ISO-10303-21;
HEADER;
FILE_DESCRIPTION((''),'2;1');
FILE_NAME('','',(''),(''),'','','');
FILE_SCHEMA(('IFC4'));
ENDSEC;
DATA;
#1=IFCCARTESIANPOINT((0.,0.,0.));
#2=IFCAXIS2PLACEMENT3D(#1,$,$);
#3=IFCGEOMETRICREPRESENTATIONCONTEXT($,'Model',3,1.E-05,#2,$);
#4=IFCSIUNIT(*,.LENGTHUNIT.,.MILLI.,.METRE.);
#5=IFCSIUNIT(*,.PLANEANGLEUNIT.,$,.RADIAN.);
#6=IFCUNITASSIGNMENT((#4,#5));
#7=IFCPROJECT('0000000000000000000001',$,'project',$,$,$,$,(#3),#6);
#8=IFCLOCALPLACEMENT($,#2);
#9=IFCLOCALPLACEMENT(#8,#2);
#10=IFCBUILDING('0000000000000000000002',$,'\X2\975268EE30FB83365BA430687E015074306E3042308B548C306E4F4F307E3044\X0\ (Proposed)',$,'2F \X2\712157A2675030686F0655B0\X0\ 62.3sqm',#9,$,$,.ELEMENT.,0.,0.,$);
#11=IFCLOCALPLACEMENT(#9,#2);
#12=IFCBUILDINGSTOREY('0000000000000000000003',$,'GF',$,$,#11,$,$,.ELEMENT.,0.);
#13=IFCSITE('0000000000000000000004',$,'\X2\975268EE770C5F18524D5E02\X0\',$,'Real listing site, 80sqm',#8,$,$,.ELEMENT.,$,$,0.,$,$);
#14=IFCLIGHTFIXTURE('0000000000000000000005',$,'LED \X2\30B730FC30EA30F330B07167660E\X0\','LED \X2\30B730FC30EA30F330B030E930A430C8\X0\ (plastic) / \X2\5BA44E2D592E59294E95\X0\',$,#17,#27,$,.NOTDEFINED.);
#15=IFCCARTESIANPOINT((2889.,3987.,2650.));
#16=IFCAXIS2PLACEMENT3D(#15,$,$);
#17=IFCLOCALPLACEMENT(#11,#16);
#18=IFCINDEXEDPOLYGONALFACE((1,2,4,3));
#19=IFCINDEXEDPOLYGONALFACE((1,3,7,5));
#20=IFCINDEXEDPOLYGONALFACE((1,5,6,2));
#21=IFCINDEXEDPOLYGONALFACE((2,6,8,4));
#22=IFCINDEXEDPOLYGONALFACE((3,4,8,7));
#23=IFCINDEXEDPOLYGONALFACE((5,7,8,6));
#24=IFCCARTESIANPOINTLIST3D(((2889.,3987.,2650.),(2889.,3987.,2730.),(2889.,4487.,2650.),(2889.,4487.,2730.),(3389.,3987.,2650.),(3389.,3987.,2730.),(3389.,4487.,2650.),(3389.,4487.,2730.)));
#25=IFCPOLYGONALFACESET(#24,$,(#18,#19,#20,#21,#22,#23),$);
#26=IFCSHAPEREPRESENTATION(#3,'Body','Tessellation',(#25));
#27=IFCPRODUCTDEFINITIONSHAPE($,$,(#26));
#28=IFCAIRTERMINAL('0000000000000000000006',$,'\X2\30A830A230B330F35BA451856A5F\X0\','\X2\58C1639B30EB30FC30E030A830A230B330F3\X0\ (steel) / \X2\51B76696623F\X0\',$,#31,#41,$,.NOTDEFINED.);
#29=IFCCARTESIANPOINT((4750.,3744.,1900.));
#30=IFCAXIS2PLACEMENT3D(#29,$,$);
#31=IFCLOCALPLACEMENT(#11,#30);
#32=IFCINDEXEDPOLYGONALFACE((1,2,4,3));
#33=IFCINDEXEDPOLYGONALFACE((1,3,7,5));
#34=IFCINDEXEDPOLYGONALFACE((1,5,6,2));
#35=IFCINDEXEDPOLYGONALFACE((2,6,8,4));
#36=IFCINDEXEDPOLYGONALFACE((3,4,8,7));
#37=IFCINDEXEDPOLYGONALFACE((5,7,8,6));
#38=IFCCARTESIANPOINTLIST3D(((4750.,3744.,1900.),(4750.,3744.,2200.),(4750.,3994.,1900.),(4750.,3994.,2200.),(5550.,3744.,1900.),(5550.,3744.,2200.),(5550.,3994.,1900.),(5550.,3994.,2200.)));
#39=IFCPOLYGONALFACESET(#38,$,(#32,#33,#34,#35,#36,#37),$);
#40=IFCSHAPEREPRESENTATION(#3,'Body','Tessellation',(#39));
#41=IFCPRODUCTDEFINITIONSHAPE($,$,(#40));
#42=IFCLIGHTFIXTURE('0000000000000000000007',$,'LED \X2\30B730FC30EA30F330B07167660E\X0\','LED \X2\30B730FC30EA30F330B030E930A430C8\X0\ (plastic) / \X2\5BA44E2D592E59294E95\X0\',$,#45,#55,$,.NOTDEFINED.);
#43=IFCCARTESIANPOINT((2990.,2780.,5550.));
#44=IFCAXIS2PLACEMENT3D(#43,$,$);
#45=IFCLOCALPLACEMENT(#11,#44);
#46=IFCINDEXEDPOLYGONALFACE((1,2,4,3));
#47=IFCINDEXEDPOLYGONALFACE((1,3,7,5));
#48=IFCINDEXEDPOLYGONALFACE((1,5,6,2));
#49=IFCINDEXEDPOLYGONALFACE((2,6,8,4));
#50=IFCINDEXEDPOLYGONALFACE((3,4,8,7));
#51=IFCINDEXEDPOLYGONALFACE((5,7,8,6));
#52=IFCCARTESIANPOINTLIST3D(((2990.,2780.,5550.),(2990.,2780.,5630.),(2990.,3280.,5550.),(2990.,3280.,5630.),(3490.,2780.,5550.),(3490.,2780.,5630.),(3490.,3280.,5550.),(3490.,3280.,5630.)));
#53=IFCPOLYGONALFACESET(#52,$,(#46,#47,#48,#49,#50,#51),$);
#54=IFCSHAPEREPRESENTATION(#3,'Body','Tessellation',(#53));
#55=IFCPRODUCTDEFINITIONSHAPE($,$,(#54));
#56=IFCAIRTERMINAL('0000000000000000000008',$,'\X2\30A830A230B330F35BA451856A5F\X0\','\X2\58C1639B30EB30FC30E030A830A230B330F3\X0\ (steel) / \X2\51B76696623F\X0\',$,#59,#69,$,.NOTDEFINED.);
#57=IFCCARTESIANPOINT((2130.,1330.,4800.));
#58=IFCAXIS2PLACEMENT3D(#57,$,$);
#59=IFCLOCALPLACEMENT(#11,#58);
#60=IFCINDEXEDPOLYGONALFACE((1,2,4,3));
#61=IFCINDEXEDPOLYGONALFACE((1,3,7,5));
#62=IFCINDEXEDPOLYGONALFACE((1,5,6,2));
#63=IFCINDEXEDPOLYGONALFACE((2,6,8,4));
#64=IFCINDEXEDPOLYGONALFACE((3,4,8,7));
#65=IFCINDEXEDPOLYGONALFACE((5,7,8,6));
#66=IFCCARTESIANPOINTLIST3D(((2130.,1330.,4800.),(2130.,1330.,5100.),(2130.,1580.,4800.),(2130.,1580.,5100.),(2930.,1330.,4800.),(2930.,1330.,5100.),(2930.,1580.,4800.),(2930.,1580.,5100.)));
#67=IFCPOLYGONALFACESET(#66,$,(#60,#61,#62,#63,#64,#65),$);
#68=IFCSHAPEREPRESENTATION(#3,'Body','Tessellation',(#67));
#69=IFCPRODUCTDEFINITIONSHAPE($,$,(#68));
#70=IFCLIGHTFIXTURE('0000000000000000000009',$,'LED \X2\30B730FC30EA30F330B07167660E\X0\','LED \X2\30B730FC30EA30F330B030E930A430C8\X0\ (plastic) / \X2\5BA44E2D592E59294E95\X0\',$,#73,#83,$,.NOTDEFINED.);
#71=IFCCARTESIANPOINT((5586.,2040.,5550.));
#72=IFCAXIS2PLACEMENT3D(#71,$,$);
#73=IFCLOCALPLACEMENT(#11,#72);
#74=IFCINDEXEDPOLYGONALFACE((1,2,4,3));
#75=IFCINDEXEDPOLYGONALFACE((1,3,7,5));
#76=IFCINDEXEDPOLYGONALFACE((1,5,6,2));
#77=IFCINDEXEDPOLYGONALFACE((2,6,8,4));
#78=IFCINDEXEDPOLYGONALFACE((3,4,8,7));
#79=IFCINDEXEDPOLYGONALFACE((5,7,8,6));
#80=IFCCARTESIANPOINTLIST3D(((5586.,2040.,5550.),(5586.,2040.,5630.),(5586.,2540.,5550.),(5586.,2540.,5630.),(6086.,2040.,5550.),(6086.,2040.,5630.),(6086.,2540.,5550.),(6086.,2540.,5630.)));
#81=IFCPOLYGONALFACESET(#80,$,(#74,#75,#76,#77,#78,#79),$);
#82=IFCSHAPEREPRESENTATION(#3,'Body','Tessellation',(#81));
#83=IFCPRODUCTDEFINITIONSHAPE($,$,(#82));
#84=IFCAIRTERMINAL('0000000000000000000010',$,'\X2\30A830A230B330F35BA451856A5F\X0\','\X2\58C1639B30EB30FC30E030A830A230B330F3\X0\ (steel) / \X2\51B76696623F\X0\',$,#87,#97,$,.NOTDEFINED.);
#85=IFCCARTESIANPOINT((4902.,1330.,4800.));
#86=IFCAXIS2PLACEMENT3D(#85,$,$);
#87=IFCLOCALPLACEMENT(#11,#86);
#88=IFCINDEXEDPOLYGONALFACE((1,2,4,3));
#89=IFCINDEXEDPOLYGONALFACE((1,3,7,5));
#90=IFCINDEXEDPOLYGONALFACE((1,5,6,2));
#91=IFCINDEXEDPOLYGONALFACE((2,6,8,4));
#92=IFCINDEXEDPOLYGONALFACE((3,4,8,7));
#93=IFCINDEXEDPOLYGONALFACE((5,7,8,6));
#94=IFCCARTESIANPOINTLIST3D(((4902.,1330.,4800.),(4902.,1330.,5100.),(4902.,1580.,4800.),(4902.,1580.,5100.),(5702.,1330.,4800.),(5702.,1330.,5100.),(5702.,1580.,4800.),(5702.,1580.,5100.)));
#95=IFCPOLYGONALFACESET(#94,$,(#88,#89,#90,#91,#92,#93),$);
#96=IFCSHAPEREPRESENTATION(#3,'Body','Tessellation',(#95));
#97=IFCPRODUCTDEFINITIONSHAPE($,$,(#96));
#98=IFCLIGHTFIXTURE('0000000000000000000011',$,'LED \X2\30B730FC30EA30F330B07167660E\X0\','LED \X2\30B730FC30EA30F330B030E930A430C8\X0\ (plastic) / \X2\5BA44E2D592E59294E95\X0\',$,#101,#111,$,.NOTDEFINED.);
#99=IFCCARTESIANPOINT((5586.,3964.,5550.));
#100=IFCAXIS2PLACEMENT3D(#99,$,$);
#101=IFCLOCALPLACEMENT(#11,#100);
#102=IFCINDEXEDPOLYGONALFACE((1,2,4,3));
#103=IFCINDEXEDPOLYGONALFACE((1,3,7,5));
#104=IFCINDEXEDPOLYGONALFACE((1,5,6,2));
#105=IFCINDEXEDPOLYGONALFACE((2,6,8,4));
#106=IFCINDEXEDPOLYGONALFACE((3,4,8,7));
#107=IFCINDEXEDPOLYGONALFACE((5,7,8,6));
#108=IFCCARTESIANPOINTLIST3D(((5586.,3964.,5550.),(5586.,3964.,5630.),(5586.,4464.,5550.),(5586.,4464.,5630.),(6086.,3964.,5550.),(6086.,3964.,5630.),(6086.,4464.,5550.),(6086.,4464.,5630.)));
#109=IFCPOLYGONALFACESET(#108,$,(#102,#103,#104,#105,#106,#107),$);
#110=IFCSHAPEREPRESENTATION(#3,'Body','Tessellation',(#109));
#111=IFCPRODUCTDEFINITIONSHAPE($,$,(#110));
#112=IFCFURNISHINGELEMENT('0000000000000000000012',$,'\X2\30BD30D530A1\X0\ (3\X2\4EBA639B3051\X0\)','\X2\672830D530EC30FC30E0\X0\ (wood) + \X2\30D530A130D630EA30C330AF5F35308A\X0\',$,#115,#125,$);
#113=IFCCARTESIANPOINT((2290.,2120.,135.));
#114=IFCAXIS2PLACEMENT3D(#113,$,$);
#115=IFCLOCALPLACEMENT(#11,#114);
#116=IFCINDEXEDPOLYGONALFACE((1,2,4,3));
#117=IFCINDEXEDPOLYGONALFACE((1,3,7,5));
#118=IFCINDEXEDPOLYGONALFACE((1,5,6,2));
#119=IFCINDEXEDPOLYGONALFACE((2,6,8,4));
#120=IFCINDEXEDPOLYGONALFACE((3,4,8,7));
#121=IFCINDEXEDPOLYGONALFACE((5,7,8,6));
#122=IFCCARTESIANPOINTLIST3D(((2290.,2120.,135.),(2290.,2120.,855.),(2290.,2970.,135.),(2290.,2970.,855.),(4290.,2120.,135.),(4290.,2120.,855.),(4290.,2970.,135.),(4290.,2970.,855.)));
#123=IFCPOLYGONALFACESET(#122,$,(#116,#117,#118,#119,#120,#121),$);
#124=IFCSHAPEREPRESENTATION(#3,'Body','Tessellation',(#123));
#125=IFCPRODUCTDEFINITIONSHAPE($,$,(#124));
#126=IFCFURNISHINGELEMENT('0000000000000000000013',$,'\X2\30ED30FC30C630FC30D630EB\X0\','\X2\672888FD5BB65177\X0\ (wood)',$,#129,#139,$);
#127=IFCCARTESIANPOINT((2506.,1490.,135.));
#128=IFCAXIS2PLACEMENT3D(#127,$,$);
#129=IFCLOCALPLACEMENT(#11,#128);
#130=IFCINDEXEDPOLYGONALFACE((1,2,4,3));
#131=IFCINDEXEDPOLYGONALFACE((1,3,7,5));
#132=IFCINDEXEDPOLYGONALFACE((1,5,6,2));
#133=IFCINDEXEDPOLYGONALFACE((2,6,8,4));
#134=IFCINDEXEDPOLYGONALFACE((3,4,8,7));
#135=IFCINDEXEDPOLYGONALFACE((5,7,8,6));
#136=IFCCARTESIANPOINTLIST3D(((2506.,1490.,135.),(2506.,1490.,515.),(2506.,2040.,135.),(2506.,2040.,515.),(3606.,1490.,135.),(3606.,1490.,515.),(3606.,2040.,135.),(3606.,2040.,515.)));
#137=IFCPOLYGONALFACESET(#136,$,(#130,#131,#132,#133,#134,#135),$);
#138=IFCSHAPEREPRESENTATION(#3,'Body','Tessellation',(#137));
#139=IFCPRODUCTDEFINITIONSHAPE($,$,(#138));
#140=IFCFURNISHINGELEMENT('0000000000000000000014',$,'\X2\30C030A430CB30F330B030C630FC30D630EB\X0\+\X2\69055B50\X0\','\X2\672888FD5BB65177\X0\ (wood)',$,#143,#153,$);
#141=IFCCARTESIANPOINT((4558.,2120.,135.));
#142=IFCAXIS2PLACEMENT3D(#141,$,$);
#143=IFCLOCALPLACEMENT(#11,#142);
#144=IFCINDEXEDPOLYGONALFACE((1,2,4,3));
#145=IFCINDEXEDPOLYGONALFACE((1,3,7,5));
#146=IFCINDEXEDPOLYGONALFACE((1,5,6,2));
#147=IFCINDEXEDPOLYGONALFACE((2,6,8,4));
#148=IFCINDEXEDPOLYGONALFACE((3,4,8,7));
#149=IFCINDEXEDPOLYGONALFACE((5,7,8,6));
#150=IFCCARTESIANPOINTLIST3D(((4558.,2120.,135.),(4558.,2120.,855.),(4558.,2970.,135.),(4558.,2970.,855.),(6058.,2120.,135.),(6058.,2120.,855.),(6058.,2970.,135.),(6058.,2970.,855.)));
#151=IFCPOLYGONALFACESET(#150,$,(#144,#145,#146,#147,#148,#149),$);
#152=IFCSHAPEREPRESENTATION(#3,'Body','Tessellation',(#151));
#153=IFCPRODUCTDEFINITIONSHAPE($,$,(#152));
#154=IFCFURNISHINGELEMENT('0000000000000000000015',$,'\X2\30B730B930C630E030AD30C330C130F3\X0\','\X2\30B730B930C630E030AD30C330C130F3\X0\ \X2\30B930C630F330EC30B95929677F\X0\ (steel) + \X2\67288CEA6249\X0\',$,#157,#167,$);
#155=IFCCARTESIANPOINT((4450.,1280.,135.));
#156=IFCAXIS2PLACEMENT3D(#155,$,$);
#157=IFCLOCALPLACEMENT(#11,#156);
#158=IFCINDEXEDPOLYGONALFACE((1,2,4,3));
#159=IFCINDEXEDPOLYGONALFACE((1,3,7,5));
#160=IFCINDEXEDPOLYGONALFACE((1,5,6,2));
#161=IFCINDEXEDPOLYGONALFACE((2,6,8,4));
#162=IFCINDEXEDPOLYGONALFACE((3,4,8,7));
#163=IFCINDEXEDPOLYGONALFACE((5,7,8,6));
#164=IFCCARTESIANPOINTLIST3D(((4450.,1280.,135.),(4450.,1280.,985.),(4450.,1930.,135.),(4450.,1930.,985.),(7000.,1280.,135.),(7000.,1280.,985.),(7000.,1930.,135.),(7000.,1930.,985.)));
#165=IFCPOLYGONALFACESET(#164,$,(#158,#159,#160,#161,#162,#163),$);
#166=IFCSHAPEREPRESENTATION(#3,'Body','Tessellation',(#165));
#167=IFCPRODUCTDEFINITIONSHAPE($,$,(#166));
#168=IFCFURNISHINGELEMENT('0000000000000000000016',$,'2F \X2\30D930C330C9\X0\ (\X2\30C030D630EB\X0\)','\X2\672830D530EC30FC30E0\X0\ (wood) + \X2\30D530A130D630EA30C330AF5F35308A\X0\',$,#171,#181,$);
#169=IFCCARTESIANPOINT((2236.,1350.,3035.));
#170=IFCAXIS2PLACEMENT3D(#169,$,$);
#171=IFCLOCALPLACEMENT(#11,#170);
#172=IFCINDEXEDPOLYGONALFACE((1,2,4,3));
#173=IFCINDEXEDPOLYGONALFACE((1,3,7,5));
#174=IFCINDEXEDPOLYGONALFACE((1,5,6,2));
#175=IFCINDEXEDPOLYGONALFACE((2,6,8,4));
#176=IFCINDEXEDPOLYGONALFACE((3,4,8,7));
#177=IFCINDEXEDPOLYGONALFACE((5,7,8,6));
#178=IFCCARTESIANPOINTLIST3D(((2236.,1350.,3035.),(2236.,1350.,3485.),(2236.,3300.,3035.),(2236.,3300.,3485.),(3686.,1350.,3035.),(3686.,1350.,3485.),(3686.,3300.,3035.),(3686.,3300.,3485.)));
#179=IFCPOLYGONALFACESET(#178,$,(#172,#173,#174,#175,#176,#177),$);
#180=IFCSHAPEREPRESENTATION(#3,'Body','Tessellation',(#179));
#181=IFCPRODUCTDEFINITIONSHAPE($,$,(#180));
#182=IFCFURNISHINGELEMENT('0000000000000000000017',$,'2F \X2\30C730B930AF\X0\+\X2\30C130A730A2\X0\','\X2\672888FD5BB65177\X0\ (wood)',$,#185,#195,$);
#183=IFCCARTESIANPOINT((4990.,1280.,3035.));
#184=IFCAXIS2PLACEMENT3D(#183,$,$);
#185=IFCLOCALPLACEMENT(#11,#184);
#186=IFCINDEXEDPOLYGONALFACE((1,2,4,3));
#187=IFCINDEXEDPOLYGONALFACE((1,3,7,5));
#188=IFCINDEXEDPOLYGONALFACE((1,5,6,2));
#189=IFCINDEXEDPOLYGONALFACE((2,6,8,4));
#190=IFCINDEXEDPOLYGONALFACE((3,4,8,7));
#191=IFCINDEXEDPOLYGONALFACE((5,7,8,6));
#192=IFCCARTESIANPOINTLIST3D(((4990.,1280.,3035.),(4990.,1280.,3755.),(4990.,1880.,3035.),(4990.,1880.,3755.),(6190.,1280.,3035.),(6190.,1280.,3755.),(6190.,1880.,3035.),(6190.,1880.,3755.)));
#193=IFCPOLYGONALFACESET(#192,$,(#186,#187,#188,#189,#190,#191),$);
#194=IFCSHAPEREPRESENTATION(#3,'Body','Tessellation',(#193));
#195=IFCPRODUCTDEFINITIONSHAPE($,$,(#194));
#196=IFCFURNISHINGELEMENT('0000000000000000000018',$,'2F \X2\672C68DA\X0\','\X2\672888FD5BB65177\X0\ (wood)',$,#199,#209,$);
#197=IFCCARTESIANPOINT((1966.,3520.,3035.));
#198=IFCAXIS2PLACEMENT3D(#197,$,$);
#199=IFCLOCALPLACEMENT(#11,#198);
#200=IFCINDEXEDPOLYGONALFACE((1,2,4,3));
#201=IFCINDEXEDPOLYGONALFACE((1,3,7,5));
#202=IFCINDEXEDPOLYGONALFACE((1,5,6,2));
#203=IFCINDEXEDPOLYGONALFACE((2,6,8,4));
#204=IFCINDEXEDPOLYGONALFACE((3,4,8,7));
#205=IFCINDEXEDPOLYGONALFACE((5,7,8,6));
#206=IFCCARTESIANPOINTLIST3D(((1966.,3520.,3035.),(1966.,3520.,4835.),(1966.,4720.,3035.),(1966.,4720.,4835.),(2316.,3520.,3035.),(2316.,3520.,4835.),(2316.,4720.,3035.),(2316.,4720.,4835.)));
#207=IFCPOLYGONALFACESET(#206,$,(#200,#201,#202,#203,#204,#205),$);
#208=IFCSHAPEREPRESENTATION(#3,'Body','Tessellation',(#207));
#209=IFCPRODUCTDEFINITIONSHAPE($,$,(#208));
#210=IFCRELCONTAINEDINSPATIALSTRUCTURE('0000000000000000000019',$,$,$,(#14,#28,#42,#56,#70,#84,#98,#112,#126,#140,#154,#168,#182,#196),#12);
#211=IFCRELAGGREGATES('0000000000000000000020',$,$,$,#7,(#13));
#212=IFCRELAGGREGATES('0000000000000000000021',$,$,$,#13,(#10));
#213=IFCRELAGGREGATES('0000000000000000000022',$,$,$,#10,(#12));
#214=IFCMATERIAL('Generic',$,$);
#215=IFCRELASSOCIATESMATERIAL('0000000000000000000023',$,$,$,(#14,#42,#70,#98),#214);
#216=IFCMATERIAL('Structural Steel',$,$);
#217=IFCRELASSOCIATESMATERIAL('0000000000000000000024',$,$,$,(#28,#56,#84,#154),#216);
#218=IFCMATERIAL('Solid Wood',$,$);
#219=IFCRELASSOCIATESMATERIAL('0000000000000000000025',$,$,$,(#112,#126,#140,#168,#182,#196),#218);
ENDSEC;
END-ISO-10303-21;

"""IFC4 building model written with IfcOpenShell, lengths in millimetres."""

from ifc_helpers import new_model, si_unit, frame, frame_2d, origin, place, context, project, spatial, rectangle, extrude, material, element, save


model = new_model("IFC4")

# Units and contexts
model_context = context("Model", 3, precision=1e-05, world=origin())
ifc_project = project(units=[si_unit("LENGTHUNIT", "METRE", prefix="MILLI"), si_unit("PLANEANGLEUNIT", "RADIAN")], contexts=[model_context])

# Site, building, storey
site_placement = place(None, origin())
site = spatial("IfcSite", under=ifc_project, at=site_placement, Name="青森県弘前市", ObjectType="Real listing site, 80sqm", CompositionType="ELEMENT", RefElevation=0.0)
building_placement = place(site_placement, origin())
building = spatial("IfcBuilding", under=site, at=building_placement, Name="青森・茶室と縁側のある和の住まい (Proposed)", ObjectType="2F 無垢材と漆喰 62.3sqm", CompositionType="ELEMENT", ElevationOfRefHeight=0.0, ElevationOfTerrain=0.0)
storey_placement = place(building_placement, origin())
storey = spatial("IfcBuildingStorey", under=building, at=storey_placement, Name="GF", CompositionType="ELEMENT", Elevation=0.0)

# Shared definitions
ifc_material_1 = material(Name="Solid Wood")

# Shared definitions
ifc_material_2 = material(Name="Structural Steel")

# Shared definitions
ifc_material_3 = material(Name="Generic")

# Light fixture
light_fixture_1_placement = place(storey_placement, frame((2889.0, 3987.0, 2650.0)))
element("IfcLightFixture", 1, at=light_fixture_1_placement, inside=storey, material=ifc_material_3, Name="LED シーリング照明", Description="LED シーリングライト (plastic) / 室中央天井", PredefinedType="NOTDEFINED", context=model_context, shape_type="SweptSolid", body=[
    extrude(rectangle(XDim=500.0, YDim=500.0, at=frame_2d((250.0, 250.0))), frame((2889.0, 3987.0, 2650.0)), (0.0, 0.0, 1.0), 80.0),
])

# Air terminal
air_terminal_1_placement = place(storey_placement, frame((4750.0, 3744.0, 1900.0)))
element("IfcAirTerminal", 2, at=air_terminal_1_placement, inside=storey, material=ifc_material_2, Name="エアコン室内機", Description="壁掛ルームエアコン (steel) / 冷暖房", PredefinedType="NOTDEFINED", context=model_context, shape_type="SweptSolid", body=[
    extrude(rectangle(XDim=800.0, YDim=250.0, at=frame_2d((400.0, 125.0))), frame((4750.0, 3744.0, 1900.0)), (0.0, 0.0, 1.0), 300.0),
])

# Light fixture
light_fixture_2_placement = place(storey_placement, frame((2990.0, 2780.0, 5550.0)))
element("IfcLightFixture", 3, at=light_fixture_2_placement, inside=storey, material=ifc_material_3, Name="LED シーリング照明", Description="LED シーリングライト (plastic) / 室中央天井", PredefinedType="NOTDEFINED", context=model_context, shape_type="SweptSolid", body=[
    extrude(rectangle(XDim=500.0, YDim=500.0, at=frame_2d((250.0, 250.0))), frame((2990.0, 2780.0, 5550.0)), (0.0, 0.0, 1.0), 80.0),
])

# Air terminal
air_terminal_2_placement = place(storey_placement, frame((2130.0, 1330.0, 4800.0)))
element("IfcAirTerminal", 4, at=air_terminal_2_placement, inside=storey, material=ifc_material_2, Name="エアコン室内機", Description="壁掛ルームエアコン (steel) / 冷暖房", PredefinedType="NOTDEFINED", context=model_context, shape_type="SweptSolid", body=[
    extrude(rectangle(XDim=800.0, YDim=250.0, at=frame_2d((400.0, 125.0))), frame((2130.0, 1330.0, 4800.0)), (0.0, 0.0, 1.0), 300.0),
])

# Light fixture
light_fixture_3_placement = place(storey_placement, frame((5586.0, 2040.0, 5550.0)))
element("IfcLightFixture", 5, at=light_fixture_3_placement, inside=storey, material=ifc_material_3, Name="LED シーリング照明", Description="LED シーリングライト (plastic) / 室中央天井", PredefinedType="NOTDEFINED", context=model_context, shape_type="SweptSolid", body=[
    extrude(rectangle(XDim=500.0, YDim=500.0, at=frame_2d((250.0, 250.0))), frame((5586.0, 2040.0, 5550.0)), (0.0, 0.0, 1.0), 80.0),
])

# Air terminal
air_terminal_3_placement = place(storey_placement, frame((4902.0, 1330.0, 4800.0)))
element("IfcAirTerminal", 6, at=air_terminal_3_placement, inside=storey, material=ifc_material_2, Name="エアコン室内機", Description="壁掛ルームエアコン (steel) / 冷暖房", PredefinedType="NOTDEFINED", context=model_context, shape_type="SweptSolid", body=[
    extrude(rectangle(XDim=800.0, YDim=250.0, at=frame_2d((400.0, 125.0))), frame((4902.0, 1330.0, 4800.0)), (0.0, 0.0, 1.0), 300.0),
])

# Light fixture
light_fixture_4_placement = place(storey_placement, frame((5586.0, 3964.0, 5550.0)))
element("IfcLightFixture", 7, at=light_fixture_4_placement, inside=storey, material=ifc_material_3, Name="LED シーリング照明", Description="LED シーリングライト (plastic) / 室中央天井", PredefinedType="NOTDEFINED", context=model_context, shape_type="SweptSolid", body=[
    extrude(rectangle(XDim=500.0, YDim=500.0, at=frame_2d((250.0, 250.0))), frame((5586.0, 3964.0, 5550.0)), (0.0, 0.0, 1.0), 80.0),
])

# Furnishing elements
furnishing_1_placement = place(storey_placement, frame((2290.0, 2120.0, 135.0)))
element("IfcFurnishingElement", 8, at=furnishing_1_placement, inside=storey, material=ifc_material_1, Name="ソファ (3人掛け)", Description="木フレーム (wood) + ファブリック張り", context=model_context, shape_type="SweptSolid", body=[
    extrude(rectangle(XDim=2000.0, YDim=850.0, at=frame_2d((1000.0, 425.0))), frame((2290.0, 2120.0, 135.0)), (0.0, 0.0, 1.0), 720.0),
])
furnishing_2_placement = place(storey_placement, frame((2506.0, 1490.0, 135.0)))
element("IfcFurnishingElement", 9, at=furnishing_2_placement, inside=storey, material=ifc_material_1, Name="ローテーブル", Description="木製家具 (wood)", context=model_context, shape_type="SweptSolid", body=[
    extrude(rectangle(XDim=1100.0, YDim=550.0, at=frame_2d((550.0, 275.0))), frame((2506.0, 1490.0, 135.0)), (0.0, 0.0, 1.0), 380.0),
])
furnishing_3_placement = place(storey_placement, frame((4558.0, 2120.0, 135.0)))
element("IfcFurnishingElement", 10, at=furnishing_3_placement, inside=storey, material=ifc_material_1, Name="ダイニングテーブル+椅子", Description="木製家具 (wood)", context=model_context, shape_type="SweptSolid", body=[
    extrude(rectangle(XDim=1500.0, YDim=850.0, at=frame_2d((750.0, 425.0))), frame((4558.0, 2120.0, 135.0)), (0.0, 0.0, 1.0), 720.0),
])
furnishing_4_placement = place(storey_placement, frame((4450.0, 1280.0, 135.0)))
element("IfcFurnishingElement", 11, at=furnishing_4_placement, inside=storey, material=ifc_material_2, Name="システムキッチン", Description="システムキッチン ステンレス天板 (steel) + 木質扉", context=model_context, shape_type="SweptSolid", body=[
    extrude(rectangle(XDim=2550.0, YDim=650.0, at=frame_2d((1275.0, 325.0))), frame((4450.0, 1280.0, 135.0)), (0.0, 0.0, 1.0), 850.0),
])
furnishing_5_placement = place(storey_placement, frame((2236.0, 1350.0, 3035.0)))
element("IfcFurnishingElement", 12, at=furnishing_5_placement, inside=storey, material=ifc_material_1, Name="2F ベッド (ダブル)", Description="木フレーム (wood) + ファブリック張り", context=model_context, shape_type="SweptSolid", body=[
    extrude(rectangle(XDim=1450.0, YDim=1950.0, at=frame_2d((725.0, 975.0))), frame((2236.0, 1350.0, 3035.0)), (0.0, 0.0, 1.0), 450.0),
])
furnishing_6_placement = place(storey_placement, frame((4990.0, 1280.0, 3035.0)))
element("IfcFurnishingElement", 13, at=furnishing_6_placement, inside=storey, material=ifc_material_1, Name="2F デスク+チェア", Description="木製家具 (wood)", context=model_context, shape_type="SweptSolid", body=[
    extrude(rectangle(XDim=1200.0, YDim=600.0, at=frame_2d((600.0, 300.0))), frame((4990.0, 1280.0, 3035.0)), (0.0, 0.0, 1.0), 720.0),
])
furnishing_7_placement = place(storey_placement, frame((1966.0, 3520.0, 3035.0)))
element("IfcFurnishingElement", 14, at=furnishing_7_placement, inside=storey, material=ifc_material_1, Name="2F 本棚", Description="木製家具 (wood)", context=model_context, shape_type="SweptSolid", body=[
    extrude(rectangle(XDim=350.0, YDim=1200.0, at=frame_2d((175.0, 600.0))), frame((1966.0, 3520.0, 3035.0)), (0.0, 0.0, 1.0), 1800.0),
])

save(model, "model.ifc")
